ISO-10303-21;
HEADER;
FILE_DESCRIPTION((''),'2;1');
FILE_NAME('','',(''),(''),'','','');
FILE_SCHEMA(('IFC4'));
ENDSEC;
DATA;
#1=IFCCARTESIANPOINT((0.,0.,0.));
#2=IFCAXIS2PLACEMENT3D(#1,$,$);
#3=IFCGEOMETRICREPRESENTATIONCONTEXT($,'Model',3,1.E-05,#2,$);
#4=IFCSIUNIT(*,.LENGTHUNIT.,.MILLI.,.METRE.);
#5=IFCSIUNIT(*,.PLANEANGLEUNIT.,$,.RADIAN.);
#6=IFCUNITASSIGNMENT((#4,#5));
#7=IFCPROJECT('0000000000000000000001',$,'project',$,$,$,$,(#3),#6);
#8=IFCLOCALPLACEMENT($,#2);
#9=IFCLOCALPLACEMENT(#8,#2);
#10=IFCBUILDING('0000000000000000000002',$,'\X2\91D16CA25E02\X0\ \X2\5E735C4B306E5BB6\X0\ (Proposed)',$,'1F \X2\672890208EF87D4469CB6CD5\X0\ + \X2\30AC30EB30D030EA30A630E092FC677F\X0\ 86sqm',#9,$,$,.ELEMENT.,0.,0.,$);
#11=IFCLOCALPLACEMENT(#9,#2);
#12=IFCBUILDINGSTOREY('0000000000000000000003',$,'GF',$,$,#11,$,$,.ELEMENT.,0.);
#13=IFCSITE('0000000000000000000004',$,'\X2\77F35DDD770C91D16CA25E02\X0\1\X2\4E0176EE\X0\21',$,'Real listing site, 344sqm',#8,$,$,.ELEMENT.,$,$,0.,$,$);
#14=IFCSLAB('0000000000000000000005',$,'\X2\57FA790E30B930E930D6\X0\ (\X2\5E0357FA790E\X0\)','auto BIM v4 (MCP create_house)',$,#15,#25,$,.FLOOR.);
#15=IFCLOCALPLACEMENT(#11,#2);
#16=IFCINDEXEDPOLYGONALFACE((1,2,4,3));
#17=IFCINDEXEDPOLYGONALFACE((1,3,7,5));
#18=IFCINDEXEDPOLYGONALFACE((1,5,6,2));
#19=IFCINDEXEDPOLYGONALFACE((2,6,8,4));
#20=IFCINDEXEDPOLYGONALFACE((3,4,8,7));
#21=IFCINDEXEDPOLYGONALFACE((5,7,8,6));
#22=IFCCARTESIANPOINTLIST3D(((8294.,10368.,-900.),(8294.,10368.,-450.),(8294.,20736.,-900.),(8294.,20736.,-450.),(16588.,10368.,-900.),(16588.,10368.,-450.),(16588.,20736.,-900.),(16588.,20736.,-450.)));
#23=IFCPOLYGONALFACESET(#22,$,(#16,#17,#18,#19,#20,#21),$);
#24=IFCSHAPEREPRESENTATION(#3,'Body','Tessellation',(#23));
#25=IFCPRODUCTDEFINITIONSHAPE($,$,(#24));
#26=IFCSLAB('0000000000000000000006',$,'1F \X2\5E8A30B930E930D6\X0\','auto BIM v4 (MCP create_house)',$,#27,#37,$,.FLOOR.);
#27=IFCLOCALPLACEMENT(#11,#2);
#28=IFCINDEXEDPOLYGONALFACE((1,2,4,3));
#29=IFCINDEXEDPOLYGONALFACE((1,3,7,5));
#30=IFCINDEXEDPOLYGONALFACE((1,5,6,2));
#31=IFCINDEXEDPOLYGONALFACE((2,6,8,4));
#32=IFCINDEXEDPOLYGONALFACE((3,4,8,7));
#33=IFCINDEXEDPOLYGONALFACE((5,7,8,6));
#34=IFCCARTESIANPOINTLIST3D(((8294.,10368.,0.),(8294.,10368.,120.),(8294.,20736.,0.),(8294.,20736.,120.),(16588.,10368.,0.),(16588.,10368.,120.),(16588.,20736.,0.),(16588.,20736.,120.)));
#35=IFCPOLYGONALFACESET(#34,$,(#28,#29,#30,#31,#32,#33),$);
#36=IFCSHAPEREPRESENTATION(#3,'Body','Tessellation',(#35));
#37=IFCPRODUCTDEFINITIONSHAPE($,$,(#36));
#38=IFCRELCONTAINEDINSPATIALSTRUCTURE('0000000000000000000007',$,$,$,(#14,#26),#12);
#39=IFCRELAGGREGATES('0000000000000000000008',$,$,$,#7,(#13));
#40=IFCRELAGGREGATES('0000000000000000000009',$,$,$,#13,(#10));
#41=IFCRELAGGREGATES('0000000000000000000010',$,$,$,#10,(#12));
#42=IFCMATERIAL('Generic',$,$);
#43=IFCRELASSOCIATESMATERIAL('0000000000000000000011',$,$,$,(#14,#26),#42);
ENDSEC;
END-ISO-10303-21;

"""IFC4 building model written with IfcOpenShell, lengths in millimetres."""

from ifc_helpers import new_model, si_unit, frame, frame_2d, origin, place, context, project, spatial, rectangle, extrude, material, element, save


model = new_model("IFC4")

# Units and contexts
model_context = context("Model", 3, precision=1e-05, world=origin())
ifc_project = project(units=[si_unit("LENGTHUNIT", "METRE", prefix="MILLI"), si_unit("PLANEANGLEUNIT", "RADIAN")], contexts=[model_context])

# Site, building, storey
site_placement = place(None, origin())
site = spatial("IfcSite", under=ifc_project, at=site_placement, Name="石川県金沢市1丁目21", ObjectType="Real listing site, 344sqm", CompositionType="ELEMENT", RefElevation=0.0)
building_placement = place(site_placement, origin())
building = spatial("IfcBuilding", under=site, at=building_placement, Name="金沢市 平屋の家 (Proposed)", ObjectType="1F 木造軸組構法 + ガルバリウム鋼板 86sqm", CompositionType="ELEMENT", ElevationOfRefHeight=0.0, ElevationOfTerrain=0.0)
storey_placement = place(building_placement, origin())
storey = spatial("IfcBuildingStorey", under=building, at=storey_placement, Name="GF", CompositionType="ELEMENT", Elevation=0.0)

# Slabs
ifc_material = material(Name="Generic")
slab_1_placement = place(storey_placement, frame((4147.0, 5184.0, -450.0)))
element("IfcSlab", 1, at=slab_1_placement, inside=storey, material=ifc_material, Name="基礎スラブ (布基礎)", Description="auto BIM v4 (MCP create_house)", PredefinedType="FLOOR", context=model_context, shape_type="SweptSolid", body=[
    extrude(rectangle(XDim=8294.0, YDim=10368.0, at=frame_2d((4147.0, 5184.0))), frame((4147.0, 5184.0, -450.0)), (0.0, 0.0, 1.0), 450.0),
])
slab_2_placement = place(storey_placement, frame((4147.0, 5184.0, 0.0)))
element("IfcSlab", 2, at=slab_2_placement, inside=storey, material=ifc_material, Name="1F 床スラブ", Description="auto BIM v4 (MCP create_house)", PredefinedType="FLOOR", context=model_context, shape_type="SweptSolid", body=[
    extrude(rectangle(XDim=8294.0, YDim=10368.0, at=frame_2d((4147.0, 5184.0))), frame((4147.0, 5184.0, 0.0)), (0.0, 0.0, 1.0), 120.0),
])

save(model, "model.ifc")
